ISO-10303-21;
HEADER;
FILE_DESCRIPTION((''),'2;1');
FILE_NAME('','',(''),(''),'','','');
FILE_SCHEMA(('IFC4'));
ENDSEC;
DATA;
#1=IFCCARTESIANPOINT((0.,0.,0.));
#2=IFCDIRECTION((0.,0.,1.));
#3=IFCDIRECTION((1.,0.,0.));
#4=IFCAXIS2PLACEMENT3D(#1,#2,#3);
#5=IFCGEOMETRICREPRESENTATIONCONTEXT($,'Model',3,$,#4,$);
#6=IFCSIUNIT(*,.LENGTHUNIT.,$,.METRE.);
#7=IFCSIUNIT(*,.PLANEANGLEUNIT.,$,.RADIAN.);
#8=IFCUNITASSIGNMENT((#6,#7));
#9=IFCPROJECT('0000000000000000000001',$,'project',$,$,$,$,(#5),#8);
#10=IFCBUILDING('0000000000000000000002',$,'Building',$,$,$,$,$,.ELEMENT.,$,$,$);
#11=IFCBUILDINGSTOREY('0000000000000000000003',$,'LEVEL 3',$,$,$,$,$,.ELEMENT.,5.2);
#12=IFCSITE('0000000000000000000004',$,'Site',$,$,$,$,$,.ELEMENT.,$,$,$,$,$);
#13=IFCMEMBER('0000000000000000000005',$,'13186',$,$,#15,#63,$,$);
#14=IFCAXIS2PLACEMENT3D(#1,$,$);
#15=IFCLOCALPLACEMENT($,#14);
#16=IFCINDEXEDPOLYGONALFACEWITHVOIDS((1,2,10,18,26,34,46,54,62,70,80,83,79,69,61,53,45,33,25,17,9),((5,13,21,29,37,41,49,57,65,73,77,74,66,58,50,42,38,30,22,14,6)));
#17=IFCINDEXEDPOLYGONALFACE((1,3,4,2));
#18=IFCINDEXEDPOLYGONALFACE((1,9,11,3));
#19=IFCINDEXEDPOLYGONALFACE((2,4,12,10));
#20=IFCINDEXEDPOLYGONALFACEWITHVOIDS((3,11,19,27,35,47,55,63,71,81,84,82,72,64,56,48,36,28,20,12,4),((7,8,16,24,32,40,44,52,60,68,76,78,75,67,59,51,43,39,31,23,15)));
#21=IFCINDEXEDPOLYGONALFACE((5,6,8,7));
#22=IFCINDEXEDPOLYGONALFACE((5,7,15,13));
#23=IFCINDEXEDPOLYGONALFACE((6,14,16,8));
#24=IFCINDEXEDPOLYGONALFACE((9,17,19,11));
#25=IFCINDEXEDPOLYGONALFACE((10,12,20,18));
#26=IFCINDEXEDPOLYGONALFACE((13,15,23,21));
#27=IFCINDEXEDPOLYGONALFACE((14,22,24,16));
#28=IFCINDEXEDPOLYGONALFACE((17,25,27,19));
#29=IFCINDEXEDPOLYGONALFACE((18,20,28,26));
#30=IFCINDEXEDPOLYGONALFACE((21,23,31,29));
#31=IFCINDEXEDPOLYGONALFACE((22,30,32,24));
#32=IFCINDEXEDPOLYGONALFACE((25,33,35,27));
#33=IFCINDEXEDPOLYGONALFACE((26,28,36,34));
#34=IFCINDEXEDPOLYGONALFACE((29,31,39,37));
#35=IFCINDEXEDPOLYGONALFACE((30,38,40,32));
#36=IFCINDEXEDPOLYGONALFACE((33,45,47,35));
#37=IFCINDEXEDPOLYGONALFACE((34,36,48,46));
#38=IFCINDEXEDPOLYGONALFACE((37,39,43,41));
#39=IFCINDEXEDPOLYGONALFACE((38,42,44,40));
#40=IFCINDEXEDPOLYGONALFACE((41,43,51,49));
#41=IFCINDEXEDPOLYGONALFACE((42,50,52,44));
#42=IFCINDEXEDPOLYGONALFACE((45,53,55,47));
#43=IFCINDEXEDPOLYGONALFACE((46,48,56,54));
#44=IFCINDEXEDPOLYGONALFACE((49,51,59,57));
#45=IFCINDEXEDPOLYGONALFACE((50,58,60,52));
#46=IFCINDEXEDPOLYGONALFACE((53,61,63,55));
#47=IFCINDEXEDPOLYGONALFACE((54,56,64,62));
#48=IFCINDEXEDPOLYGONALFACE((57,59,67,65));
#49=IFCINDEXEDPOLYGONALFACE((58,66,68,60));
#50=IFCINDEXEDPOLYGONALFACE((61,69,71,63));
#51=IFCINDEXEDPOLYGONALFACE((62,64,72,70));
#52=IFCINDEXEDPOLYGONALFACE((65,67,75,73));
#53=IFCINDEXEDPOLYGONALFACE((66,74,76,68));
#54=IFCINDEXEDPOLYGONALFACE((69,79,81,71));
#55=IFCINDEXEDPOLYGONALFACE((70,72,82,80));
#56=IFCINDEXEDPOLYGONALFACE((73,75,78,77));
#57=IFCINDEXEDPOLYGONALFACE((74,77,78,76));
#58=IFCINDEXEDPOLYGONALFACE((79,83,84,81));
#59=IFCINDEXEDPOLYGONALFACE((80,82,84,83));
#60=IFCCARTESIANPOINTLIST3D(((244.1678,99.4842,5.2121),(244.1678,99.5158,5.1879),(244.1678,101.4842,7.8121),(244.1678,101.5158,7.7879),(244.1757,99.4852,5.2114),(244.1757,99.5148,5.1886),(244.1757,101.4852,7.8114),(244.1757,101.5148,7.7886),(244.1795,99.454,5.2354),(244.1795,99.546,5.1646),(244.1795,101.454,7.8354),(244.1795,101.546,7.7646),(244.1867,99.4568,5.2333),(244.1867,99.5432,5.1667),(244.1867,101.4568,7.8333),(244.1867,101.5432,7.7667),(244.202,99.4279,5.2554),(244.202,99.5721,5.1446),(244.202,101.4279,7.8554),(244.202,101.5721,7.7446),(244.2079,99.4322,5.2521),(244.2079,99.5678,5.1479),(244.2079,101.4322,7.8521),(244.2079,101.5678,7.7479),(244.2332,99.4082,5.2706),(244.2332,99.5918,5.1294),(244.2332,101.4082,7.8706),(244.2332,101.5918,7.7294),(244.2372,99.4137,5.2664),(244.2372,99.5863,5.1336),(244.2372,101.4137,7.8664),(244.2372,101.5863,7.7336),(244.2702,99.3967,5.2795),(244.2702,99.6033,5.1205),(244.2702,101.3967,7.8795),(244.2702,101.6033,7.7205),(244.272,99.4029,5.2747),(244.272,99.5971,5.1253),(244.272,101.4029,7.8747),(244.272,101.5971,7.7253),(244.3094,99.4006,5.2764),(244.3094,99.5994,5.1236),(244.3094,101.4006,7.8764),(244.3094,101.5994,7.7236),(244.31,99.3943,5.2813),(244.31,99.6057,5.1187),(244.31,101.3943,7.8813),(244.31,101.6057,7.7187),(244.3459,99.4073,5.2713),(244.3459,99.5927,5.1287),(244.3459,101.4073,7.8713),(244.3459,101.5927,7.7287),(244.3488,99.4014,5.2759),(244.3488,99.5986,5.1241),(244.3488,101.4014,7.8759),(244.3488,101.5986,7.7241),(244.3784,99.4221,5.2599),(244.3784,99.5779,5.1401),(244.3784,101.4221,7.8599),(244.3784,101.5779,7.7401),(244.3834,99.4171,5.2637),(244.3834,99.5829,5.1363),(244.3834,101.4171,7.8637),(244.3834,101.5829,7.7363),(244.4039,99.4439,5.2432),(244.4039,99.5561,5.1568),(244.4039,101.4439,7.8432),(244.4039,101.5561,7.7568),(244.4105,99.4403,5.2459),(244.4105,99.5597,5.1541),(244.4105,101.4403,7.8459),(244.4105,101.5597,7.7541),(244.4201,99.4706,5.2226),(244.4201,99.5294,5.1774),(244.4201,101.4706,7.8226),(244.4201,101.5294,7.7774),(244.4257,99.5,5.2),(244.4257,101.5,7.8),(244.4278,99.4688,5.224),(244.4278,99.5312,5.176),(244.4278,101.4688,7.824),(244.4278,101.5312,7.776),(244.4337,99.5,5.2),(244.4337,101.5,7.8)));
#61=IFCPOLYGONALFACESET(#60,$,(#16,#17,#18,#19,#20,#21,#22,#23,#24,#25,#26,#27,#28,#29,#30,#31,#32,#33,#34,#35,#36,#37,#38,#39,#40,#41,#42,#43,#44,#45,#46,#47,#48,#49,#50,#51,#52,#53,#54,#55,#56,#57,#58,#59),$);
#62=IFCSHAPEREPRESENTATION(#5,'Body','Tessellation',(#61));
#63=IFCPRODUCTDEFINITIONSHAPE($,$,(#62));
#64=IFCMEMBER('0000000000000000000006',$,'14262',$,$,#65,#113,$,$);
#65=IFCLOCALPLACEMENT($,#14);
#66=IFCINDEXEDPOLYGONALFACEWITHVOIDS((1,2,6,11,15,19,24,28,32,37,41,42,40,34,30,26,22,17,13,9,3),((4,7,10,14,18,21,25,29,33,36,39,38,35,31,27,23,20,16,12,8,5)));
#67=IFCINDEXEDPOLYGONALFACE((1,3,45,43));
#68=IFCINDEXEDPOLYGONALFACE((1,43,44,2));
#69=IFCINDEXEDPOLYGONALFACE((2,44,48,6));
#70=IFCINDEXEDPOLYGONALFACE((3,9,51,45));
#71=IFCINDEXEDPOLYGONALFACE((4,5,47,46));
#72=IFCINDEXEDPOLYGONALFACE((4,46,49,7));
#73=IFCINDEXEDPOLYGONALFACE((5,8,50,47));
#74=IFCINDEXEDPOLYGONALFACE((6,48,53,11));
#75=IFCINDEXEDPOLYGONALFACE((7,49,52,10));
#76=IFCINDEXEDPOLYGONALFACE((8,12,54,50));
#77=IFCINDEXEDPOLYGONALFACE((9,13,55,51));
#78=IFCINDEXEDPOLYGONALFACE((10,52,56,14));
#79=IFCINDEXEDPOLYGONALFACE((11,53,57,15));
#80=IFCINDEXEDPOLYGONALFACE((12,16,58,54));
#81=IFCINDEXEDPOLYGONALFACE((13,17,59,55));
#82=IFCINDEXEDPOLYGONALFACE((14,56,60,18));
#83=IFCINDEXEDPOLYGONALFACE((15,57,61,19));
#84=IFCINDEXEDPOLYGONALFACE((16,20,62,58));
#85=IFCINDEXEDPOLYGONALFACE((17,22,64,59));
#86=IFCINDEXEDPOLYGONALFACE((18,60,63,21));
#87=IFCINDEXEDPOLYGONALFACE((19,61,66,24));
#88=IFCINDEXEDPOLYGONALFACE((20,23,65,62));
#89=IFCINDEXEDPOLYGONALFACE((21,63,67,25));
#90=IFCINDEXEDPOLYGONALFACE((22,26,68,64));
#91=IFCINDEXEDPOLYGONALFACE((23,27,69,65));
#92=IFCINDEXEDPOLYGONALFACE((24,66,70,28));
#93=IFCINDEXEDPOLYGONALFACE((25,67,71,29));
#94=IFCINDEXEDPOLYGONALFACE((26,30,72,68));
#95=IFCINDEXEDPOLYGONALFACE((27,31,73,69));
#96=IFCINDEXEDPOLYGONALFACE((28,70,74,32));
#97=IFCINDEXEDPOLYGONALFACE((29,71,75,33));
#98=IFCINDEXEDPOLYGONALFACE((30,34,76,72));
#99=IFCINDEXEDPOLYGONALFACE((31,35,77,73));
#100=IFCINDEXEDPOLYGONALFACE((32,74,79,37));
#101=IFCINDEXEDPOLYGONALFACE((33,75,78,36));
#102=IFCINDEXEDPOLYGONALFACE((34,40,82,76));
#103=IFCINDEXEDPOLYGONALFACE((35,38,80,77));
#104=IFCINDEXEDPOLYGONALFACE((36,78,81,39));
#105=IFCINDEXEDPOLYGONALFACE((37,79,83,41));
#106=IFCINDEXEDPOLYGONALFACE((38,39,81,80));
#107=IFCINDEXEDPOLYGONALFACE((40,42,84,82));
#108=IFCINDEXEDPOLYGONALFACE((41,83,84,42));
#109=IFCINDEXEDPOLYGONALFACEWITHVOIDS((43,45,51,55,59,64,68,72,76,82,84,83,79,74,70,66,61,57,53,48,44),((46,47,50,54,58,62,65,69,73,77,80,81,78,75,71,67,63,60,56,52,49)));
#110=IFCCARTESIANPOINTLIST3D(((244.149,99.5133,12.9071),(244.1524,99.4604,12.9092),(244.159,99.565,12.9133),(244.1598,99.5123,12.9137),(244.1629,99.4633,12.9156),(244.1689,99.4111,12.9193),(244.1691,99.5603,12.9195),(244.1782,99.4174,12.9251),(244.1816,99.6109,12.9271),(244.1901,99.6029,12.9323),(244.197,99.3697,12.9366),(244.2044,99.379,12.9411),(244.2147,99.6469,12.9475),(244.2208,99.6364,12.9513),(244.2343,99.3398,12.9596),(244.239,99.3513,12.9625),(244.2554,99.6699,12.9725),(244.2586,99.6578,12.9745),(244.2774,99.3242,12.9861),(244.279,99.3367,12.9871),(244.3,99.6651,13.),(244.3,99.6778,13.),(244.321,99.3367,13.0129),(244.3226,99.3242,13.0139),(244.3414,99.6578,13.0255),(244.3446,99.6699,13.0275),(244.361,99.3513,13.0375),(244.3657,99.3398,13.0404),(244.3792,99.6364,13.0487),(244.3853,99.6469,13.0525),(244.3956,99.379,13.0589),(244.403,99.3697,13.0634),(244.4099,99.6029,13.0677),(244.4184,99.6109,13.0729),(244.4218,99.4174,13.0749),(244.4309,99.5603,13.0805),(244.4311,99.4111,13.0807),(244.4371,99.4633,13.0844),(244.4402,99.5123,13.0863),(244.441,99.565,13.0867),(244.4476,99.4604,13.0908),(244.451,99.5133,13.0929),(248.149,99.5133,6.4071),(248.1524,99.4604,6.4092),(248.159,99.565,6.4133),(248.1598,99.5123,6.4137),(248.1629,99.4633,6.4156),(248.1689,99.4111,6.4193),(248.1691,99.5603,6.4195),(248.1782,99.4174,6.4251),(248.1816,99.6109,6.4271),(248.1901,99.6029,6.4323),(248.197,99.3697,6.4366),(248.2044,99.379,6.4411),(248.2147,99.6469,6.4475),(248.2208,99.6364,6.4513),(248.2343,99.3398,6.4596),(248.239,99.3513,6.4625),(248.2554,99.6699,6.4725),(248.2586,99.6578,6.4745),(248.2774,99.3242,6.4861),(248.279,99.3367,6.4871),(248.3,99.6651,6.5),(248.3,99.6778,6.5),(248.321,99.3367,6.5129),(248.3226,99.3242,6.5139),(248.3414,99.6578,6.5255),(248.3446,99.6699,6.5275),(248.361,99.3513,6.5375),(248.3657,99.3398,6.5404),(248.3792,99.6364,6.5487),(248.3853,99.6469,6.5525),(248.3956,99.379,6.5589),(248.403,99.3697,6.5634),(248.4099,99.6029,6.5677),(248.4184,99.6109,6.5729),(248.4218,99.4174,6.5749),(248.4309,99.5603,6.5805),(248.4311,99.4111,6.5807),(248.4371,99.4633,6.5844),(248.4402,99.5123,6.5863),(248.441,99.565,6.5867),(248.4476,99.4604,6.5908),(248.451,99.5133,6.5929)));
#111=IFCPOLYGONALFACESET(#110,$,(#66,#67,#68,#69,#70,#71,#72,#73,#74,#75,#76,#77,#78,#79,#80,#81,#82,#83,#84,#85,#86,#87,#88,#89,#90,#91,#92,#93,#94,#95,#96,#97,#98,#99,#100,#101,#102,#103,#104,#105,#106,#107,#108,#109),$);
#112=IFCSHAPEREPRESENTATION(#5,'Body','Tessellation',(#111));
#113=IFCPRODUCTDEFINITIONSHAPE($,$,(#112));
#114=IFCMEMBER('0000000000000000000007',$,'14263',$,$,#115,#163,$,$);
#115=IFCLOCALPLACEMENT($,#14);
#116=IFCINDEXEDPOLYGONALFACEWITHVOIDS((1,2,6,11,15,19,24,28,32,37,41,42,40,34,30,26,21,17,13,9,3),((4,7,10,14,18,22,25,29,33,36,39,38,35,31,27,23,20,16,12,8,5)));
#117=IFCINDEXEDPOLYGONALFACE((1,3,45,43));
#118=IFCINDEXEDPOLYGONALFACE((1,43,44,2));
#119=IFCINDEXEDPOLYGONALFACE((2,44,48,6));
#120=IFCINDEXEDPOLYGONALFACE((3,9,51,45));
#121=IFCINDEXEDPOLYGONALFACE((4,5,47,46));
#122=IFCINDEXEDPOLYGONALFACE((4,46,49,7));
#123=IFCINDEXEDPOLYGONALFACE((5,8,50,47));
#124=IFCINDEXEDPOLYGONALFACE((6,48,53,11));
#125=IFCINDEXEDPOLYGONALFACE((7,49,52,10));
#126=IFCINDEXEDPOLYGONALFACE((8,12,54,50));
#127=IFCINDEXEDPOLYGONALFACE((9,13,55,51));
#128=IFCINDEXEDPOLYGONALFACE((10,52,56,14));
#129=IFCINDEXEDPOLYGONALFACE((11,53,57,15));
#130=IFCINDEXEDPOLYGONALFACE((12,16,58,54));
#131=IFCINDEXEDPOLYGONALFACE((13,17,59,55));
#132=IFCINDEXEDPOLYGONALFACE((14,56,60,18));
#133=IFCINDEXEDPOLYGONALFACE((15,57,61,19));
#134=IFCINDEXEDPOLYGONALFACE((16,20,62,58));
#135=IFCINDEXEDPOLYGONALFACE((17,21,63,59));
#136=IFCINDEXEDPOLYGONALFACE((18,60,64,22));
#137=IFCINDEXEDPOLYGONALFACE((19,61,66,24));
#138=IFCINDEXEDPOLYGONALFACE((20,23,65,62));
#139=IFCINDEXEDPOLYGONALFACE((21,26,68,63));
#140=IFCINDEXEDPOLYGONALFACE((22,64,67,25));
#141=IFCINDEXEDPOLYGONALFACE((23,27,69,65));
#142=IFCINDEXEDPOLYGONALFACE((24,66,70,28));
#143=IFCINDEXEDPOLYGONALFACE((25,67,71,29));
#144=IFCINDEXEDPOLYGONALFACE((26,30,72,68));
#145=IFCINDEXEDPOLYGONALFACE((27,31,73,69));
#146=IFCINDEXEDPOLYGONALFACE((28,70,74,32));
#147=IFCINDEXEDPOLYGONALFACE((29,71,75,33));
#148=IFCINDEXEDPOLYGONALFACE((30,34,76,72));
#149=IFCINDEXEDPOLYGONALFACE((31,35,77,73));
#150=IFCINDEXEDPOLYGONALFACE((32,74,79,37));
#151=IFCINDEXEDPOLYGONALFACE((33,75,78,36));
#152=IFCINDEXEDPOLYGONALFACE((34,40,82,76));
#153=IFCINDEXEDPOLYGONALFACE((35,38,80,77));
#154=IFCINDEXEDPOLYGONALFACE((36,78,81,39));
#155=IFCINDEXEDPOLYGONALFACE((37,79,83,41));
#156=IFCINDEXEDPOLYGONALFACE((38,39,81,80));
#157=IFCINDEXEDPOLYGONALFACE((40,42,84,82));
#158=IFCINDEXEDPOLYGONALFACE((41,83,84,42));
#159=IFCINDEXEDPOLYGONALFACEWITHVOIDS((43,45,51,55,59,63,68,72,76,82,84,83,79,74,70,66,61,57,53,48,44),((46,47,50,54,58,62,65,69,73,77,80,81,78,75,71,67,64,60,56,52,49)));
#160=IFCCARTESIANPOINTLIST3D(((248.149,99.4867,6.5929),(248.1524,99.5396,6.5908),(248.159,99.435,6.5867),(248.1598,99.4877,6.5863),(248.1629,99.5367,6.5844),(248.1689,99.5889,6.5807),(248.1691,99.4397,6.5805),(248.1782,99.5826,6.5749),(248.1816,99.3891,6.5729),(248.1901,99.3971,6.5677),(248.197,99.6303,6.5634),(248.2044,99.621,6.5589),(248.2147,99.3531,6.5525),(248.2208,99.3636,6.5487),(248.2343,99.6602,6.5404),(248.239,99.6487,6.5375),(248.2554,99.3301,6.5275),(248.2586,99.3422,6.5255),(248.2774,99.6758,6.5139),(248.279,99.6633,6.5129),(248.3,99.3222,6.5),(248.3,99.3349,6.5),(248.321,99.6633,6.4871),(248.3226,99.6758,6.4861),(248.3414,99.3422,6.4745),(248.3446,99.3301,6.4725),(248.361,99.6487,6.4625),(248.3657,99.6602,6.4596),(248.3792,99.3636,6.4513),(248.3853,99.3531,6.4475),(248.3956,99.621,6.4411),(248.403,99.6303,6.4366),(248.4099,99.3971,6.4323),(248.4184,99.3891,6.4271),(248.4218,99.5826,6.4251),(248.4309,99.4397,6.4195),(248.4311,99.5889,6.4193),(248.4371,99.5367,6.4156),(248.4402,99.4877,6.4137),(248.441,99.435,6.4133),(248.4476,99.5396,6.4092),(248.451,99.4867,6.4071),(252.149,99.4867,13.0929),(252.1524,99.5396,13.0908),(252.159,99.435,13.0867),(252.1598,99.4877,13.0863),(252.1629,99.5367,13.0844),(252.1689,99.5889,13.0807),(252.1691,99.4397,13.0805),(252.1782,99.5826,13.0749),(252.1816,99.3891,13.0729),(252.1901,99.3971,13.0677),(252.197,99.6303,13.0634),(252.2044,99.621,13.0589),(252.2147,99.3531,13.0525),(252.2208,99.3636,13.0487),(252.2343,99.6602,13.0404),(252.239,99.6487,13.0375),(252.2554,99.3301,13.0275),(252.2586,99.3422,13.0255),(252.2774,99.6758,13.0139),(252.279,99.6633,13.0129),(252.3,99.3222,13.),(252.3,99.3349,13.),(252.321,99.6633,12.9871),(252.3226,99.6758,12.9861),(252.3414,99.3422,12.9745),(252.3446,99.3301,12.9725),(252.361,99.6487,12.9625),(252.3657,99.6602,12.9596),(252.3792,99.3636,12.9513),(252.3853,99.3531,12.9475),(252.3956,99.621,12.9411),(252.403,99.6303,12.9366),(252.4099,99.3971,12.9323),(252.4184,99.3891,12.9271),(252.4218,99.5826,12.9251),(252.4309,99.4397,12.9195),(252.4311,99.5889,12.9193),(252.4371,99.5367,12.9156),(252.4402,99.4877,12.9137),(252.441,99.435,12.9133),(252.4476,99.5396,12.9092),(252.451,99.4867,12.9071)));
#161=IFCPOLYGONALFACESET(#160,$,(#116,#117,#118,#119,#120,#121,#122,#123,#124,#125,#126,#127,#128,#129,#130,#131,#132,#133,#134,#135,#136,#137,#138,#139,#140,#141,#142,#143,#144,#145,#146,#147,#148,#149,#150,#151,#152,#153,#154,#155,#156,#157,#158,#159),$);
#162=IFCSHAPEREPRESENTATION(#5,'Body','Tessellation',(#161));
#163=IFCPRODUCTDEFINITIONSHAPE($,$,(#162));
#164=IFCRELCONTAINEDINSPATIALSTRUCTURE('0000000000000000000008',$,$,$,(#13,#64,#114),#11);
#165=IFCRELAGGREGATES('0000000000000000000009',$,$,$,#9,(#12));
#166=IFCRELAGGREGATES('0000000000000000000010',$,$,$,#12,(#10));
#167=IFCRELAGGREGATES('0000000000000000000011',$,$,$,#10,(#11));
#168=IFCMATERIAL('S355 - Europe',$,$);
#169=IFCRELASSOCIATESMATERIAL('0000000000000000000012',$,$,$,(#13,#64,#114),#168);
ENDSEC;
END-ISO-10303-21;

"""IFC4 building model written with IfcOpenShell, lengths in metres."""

from ifc_helpers import new_model, si_unit, frame, origin_with_axes, origin_2d_with_axis, place, context, project, spatial, hollow_circle, extrude, material, material_profile, profile_set, profile_usage, element, save


model = new_model("IFC4")

# Units and contexts
model_context = context("Model", 3, world=origin_with_axes())
ifc_project = project(units=[si_unit("LENGTHUNIT", "METRE"), si_unit("PLANEANGLEUNIT", "RADIAN")], contexts=[model_context])

# Site, building, storey
site = spatial("IfcSite", under=ifc_project, Name="Site", CompositionType="ELEMENT")
building = spatial("IfcBuilding", under=site, Name="Building", CompositionType="ELEMENT")
storey = spatial("IfcBuildingStorey", under=building, Name="LEVEL 3", CompositionType="ELEMENT", Elevation=5.2)

# Shared definitions
ifc_material = material(Name="S355 - Europe")

# Members
ifc_material_profile_1 = material_profile(ifc_material, hollow_circle(Radius=0.1337, WallThickness=0.008, at=origin_2d_with_axis()))
ifc_profile_set_1 = profile_set([ifc_material_profile_1])
ifc_profile_usage_1 = profile_usage(ifc_profile_set_1, cardinal=10)
member_1_placement = place(None, frame((244.3, 101.5, 7.8), z_axis=(0.0, -0.609711, -0.792624), x_axis=(1.0, 0.0, 0.0)))
element("IfcMember", 1, at=member_1_placement, inside=storey, material=ifc_profile_usage_1, Name="13186", context=model_context, shape_type="SweptSolid", body=[
    extrude(hollow_circle(Radius=0.1337, WallThickness=0.008, at=origin_2d_with_axis()), origin_with_axes(), (0.0, 0.0, 1.0), 3.2802),
])
ifc_material_profile_2 = material_profile(ifc_material, hollow_circle(Radius=0.1778, WallThickness=0.0127, at=origin_2d_with_axis()))
ifc_profile_set_2 = profile_set([ifc_material_profile_2])
ifc_profile_usage_2 = profile_usage(ifc_profile_set_2, cardinal=10)
member_2_placement = place(None, frame((244.3, 99.5, 13.0), z_axis=(0.524097, 0.0, -0.851658), x_axis=(0.0, 1.0, 0.0)))
element("IfcMember", 2, at=member_2_placement, inside=storey, material=ifc_profile_usage_2, Name="14262", context=model_context, shape_type="SweptSolid", body=[
    extrude(hollow_circle(Radius=0.1778, WallThickness=0.0127, at=origin_2d_with_axis()), origin_with_axes(), (0.0, 0.0, 1.0), 7.6322),
])
ifc_material_profile_3 = material_profile(ifc_material, hollow_circle(Radius=0.1778, WallThickness=0.0127, at=origin_2d_with_axis()))
ifc_profile_set_3 = profile_set([ifc_material_profile_3])
ifc_profile_usage_3 = profile_usage(ifc_profile_set_3, cardinal=10)
member_3_placement = place(None, frame((252.3, 99.5, 13.0), z_axis=(-0.524097, 0.0, -0.851658), x_axis=(0.0, -1.0, 0.0)))
element("IfcMember", 3, at=member_3_placement, inside=storey, material=ifc_profile_usage_3, Name="14263", context=model_context, shape_type="SweptSolid", body=[
    extrude(hollow_circle(Radius=0.1778, WallThickness=0.0127, at=origin_2d_with_axis()), origin_with_axes(), (0.0, 0.0, 1.0), 7.6322),
])

save(model, "model.ifc")
